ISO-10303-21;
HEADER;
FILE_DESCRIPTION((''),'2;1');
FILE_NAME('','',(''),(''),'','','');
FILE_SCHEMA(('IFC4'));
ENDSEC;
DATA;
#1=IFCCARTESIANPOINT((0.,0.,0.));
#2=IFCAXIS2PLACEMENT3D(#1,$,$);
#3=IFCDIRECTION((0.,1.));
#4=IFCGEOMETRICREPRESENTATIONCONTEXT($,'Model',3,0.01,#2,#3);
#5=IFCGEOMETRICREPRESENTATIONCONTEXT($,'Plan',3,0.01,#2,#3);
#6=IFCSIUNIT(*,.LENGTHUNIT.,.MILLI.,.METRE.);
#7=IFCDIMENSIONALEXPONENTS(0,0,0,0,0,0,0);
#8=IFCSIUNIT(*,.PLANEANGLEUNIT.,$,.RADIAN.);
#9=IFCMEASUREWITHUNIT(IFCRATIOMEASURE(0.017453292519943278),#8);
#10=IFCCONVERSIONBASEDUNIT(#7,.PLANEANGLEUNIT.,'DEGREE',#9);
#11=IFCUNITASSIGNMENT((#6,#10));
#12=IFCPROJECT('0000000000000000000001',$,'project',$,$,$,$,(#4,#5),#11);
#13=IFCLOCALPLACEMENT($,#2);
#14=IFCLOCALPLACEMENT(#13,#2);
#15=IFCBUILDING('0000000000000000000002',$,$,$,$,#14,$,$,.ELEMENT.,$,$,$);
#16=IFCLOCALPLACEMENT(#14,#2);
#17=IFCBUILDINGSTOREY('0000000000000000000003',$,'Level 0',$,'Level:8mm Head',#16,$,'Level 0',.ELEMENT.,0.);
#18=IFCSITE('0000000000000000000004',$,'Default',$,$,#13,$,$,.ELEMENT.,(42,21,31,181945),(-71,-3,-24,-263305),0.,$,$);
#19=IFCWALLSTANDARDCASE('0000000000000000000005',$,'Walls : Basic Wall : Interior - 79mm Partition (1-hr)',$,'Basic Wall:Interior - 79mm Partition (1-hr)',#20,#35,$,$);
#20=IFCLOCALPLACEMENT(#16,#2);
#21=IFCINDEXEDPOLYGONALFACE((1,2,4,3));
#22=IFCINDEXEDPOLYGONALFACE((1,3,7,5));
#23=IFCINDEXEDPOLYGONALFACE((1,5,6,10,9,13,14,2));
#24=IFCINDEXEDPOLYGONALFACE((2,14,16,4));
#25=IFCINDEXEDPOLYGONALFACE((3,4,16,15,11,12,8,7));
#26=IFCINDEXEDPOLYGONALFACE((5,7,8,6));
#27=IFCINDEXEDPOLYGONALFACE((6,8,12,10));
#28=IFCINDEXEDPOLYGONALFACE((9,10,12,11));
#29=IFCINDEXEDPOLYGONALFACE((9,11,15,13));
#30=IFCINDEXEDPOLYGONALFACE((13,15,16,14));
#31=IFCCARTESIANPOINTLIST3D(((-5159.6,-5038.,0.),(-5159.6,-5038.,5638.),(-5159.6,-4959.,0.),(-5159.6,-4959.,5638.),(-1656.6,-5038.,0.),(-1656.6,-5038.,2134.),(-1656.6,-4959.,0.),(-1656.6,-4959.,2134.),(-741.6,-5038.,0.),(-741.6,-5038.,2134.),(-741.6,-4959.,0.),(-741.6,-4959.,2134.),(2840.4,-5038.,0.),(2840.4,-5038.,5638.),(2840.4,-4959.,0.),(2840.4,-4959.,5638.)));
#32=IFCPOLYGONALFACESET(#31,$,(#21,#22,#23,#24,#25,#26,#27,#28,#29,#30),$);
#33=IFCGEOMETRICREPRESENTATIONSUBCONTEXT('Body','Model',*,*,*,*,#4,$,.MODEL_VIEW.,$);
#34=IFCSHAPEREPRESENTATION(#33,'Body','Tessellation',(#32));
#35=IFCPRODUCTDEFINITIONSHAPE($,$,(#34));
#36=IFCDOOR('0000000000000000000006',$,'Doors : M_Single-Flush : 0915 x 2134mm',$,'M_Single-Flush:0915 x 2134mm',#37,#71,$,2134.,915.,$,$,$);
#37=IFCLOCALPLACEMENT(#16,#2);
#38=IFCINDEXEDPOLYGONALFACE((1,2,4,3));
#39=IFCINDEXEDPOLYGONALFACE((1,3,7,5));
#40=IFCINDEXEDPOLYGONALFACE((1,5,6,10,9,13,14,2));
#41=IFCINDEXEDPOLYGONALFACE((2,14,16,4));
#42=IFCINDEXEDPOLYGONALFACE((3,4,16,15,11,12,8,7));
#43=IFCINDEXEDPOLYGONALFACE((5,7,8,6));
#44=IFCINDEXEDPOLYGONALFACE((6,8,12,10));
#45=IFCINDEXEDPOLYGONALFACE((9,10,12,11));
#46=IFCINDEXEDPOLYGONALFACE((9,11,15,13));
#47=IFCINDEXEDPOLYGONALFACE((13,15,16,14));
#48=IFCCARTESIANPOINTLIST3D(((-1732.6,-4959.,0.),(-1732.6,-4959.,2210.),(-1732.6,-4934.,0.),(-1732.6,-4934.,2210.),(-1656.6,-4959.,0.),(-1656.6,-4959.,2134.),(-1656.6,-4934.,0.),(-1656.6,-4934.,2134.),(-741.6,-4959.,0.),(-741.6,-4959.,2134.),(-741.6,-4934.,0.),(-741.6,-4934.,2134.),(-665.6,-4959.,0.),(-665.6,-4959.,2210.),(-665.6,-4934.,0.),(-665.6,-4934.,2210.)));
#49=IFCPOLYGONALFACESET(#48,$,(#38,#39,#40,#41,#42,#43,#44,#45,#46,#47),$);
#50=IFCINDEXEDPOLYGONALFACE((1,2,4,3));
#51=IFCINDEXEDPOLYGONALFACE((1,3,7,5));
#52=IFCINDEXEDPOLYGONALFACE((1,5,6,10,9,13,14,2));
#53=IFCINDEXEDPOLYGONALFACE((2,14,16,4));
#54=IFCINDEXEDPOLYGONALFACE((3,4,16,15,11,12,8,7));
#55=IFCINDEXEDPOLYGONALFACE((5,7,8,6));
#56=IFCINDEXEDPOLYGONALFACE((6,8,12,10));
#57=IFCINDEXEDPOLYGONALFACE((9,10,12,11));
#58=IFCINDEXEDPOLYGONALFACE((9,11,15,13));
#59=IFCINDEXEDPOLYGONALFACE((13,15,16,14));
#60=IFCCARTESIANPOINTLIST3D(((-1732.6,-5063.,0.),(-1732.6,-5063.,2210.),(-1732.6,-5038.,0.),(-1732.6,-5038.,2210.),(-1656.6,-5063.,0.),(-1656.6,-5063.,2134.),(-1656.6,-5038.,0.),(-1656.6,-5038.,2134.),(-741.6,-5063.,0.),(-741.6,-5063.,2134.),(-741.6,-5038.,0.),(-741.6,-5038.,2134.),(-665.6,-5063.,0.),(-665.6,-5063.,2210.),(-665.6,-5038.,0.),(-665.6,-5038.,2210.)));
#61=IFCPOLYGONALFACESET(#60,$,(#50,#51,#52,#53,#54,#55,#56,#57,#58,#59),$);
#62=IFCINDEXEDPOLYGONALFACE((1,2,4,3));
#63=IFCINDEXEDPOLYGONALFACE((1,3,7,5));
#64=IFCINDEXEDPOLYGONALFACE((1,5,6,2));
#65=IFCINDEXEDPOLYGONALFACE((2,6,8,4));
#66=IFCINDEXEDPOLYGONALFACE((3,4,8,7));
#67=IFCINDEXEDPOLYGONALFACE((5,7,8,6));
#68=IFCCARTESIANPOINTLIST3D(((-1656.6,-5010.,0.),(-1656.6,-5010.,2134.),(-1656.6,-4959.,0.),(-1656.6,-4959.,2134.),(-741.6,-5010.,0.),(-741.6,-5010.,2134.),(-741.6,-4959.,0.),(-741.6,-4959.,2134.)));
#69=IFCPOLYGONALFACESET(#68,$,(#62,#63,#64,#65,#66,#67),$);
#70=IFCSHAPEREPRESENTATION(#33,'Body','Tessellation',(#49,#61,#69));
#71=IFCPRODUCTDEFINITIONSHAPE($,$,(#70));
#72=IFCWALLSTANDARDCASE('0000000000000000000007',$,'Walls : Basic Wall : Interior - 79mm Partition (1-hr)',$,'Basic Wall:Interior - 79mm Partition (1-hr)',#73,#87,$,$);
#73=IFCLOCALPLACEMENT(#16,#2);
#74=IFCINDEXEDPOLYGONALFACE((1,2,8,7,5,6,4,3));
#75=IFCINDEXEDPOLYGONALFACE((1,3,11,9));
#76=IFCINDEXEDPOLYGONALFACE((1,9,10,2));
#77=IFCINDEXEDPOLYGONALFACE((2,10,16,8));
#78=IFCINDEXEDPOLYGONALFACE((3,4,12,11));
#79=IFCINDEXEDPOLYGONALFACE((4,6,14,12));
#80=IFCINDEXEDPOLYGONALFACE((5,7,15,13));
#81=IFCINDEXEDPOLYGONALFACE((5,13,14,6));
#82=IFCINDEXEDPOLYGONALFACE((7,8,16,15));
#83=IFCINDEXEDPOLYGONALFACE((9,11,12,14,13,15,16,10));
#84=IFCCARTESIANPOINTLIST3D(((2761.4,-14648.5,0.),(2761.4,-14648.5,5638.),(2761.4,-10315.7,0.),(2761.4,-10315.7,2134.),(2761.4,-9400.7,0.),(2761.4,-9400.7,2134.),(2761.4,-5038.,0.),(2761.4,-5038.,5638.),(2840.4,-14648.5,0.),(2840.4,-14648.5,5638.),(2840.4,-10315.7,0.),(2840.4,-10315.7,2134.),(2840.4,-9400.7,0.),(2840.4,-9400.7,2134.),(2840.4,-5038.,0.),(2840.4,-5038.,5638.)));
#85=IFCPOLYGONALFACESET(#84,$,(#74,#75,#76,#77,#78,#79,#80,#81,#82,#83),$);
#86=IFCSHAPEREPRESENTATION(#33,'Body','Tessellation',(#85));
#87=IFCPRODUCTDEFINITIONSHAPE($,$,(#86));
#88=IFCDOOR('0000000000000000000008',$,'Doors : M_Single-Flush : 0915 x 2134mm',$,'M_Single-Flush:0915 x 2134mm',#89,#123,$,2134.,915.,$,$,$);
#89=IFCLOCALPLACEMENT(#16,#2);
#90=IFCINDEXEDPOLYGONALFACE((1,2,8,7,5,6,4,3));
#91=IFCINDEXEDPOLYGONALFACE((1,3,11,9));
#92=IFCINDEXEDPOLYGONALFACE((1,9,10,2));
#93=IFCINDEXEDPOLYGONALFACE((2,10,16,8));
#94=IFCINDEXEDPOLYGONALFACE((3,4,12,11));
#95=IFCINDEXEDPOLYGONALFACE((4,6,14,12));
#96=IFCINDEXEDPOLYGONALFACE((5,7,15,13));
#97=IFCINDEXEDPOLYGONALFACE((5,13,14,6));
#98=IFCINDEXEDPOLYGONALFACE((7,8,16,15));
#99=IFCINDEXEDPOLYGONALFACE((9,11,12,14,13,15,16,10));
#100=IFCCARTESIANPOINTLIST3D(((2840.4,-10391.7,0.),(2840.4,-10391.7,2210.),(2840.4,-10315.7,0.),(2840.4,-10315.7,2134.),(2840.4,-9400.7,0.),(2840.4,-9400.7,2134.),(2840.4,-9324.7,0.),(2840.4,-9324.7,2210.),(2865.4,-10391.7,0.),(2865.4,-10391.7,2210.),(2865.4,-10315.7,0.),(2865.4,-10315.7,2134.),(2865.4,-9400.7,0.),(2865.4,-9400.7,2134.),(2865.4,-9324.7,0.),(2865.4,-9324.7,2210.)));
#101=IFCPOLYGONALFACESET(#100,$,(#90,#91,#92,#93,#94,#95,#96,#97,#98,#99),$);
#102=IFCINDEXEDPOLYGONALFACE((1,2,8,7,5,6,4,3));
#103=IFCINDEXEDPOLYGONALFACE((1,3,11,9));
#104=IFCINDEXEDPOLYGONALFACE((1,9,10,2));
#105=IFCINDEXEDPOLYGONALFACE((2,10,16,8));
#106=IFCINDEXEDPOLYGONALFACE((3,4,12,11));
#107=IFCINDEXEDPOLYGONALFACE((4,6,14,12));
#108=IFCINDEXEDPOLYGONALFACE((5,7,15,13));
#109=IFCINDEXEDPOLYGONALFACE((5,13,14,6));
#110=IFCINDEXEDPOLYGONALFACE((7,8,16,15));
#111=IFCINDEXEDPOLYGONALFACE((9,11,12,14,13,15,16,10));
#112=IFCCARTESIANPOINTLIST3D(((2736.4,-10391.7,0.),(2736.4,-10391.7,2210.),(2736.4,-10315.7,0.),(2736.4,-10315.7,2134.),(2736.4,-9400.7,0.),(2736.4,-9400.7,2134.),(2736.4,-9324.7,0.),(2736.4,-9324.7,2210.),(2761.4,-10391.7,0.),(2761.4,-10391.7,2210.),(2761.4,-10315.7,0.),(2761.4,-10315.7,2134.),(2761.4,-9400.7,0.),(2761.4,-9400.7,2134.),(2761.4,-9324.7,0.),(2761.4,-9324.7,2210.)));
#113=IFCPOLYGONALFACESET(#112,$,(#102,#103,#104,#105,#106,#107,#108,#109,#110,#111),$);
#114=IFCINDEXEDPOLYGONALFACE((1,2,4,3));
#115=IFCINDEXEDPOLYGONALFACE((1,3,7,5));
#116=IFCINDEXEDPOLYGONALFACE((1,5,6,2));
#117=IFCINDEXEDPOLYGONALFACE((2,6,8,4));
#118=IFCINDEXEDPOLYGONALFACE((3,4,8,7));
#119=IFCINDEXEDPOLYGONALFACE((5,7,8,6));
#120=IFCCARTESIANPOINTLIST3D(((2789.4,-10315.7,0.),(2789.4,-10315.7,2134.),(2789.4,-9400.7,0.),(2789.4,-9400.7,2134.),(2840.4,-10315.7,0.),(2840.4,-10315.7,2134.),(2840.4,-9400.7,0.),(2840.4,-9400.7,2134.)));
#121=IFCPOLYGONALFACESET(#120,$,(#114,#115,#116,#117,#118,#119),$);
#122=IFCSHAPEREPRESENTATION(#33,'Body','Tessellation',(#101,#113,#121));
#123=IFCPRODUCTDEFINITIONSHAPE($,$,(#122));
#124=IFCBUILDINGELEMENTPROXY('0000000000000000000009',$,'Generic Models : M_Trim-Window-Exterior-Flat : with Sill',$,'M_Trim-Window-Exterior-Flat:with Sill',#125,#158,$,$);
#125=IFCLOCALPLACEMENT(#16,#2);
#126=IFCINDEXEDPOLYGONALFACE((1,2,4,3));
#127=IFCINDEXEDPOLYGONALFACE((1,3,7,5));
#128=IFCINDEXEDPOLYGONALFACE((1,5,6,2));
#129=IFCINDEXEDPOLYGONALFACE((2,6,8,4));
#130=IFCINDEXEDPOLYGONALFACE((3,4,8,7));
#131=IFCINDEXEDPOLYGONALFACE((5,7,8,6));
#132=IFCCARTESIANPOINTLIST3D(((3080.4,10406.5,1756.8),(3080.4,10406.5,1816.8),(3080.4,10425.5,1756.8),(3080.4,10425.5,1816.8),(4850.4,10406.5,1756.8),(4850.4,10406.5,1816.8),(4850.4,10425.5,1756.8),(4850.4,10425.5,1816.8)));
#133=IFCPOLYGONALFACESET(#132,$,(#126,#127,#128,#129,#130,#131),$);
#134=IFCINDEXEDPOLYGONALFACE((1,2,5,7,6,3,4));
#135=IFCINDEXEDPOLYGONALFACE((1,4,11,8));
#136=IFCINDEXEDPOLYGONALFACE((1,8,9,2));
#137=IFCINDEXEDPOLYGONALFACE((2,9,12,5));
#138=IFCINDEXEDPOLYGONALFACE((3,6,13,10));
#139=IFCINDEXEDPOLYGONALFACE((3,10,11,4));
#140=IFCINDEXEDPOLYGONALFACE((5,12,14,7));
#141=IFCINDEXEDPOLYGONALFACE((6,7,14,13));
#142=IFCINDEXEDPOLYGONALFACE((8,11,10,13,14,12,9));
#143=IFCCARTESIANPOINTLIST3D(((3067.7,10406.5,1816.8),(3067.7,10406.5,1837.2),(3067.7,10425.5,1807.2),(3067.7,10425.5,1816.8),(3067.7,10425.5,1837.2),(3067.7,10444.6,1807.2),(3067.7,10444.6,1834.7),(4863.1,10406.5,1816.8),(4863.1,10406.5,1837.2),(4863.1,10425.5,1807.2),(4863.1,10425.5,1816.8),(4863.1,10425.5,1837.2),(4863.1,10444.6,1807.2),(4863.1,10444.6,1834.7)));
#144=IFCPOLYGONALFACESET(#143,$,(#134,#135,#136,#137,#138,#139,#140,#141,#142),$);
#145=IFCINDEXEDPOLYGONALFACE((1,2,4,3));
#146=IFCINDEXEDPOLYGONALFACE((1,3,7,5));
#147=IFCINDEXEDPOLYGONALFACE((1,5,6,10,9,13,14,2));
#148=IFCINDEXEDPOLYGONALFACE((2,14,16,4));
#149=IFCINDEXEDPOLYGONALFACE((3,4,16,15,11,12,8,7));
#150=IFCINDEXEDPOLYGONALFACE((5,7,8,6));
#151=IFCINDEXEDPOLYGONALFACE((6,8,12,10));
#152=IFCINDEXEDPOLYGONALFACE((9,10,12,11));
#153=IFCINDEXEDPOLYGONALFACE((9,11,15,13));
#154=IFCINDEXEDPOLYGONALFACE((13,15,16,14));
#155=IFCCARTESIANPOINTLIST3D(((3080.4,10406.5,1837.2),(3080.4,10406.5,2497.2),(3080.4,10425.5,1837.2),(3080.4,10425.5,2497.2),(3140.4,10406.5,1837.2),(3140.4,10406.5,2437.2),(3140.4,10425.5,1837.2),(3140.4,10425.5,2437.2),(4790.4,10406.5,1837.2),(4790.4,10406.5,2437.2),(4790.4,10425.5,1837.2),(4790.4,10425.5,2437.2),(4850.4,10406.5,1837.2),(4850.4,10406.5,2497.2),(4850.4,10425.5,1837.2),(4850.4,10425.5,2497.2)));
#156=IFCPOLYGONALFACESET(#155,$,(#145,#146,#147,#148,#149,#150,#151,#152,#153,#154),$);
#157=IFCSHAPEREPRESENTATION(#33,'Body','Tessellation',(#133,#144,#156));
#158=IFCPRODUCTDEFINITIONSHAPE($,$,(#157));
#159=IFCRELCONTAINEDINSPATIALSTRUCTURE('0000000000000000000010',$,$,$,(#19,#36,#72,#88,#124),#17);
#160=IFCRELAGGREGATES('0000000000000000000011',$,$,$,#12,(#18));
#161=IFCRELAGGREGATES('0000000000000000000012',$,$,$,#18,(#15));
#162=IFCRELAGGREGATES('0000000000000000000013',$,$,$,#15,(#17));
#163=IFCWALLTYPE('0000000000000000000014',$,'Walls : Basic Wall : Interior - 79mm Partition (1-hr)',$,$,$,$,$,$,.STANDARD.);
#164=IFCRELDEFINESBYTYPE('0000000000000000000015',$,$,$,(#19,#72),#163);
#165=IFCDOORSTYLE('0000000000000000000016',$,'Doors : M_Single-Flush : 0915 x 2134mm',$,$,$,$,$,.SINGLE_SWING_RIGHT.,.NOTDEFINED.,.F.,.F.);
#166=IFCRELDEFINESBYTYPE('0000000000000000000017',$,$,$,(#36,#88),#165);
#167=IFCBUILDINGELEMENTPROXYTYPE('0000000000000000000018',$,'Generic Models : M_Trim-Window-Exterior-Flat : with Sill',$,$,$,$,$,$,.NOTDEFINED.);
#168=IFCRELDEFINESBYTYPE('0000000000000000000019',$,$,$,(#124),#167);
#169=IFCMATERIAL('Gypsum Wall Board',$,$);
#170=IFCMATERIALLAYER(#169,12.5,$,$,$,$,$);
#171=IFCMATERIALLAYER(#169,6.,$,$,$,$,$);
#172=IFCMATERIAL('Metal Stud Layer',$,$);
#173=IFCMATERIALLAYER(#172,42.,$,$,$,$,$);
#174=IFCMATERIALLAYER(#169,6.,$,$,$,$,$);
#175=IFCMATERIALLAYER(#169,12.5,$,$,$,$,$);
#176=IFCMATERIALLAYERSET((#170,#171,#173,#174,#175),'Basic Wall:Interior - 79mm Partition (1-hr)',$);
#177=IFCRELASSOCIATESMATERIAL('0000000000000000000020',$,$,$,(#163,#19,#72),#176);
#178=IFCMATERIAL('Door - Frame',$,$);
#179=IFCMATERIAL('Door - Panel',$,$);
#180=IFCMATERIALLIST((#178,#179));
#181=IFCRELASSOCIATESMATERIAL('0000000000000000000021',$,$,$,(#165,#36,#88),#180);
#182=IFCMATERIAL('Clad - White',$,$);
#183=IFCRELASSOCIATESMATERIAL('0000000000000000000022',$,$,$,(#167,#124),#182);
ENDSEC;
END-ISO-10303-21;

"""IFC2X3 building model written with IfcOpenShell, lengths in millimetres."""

from ifc_helpers import new_model, entity, si_unit, converted_unit, direction, frame, frame_2d, origin, origin_2d_with_axis, place, context, subcontext, project, spatial, polyline, rectangle, outline, extrude, clip, bounded_halfspace, source, transform, mapped, material, material_list, layer, layer_set, layer_usage, type_object, type_shapes, element, fill, save


model = new_model("IFC2X3")

# Units and contexts
model_context = context("Model", 3, precision=0.01, world=origin(), true_north=direction((0.0, 1.0)))
plan_context = context("Plan", 3, precision=0.01, world=origin(), true_north=direction((0.0, 1.0)))
body_context = subcontext(model_context, "Body", "Model", "MODEL_VIEW")
ifc_project = project(units=[si_unit("LENGTHUNIT", "METRE", prefix="MILLI"), converted_unit("PLANEANGLEUNIT", "DEGREE", entity("IfcRatioMeasure", 0.017453292519943278), si_unit("PLANEANGLEUNIT", "RADIAN"), dimensions=[0, 0, 0, 0, 0, 0, 0])], contexts=[model_context, plan_context])

# Site, building, storey
site_placement = place(None, origin())
site = spatial("IfcSite", under=ifc_project, at=site_placement, Name="Default", CompositionType="ELEMENT", RefLatitude=(42, 21, 31, 181945), RefLongitude=(-71, -3, -24, -263305), RefElevation=0.0)
building_placement = place(site_placement, origin())
building = spatial("IfcBuilding", under=site, at=building_placement, CompositionType="ELEMENT")
storey_placement = place(building_placement, origin())
storey = spatial("IfcBuildingStorey", under=building, at=storey_placement, Name="Level 0", ObjectType="Level:8mm Head", LongName="Level 0", CompositionType="ELEMENT", Elevation=0.0)

# Shared definitions
ifc_material_1 = material(Name="Metal Stud Layer")
ifc_material_2 = material(Name="Gypsum Wall Board")

# Shared definitions
ifc_material_3 = material(Name="Door - Frame")
ifc_material_4 = material(Name="Door - Panel")
ifc_material_list = material_list([ifc_material_3, ifc_material_4])

# Walls, openings, doors
ifc_layer_1 = layer(ifc_material_2, 12.5)
ifc_layer_2 = layer(ifc_material_2, 6.0)
ifc_layer_3 = layer(ifc_material_1, 42.0)
ifc_layer_4 = layer(ifc_material_2, 6.0)
ifc_layer_5 = layer(ifc_material_2, 12.5)
ifc_layer_set_1 = layer_set([ifc_layer_1, ifc_layer_2, ifc_layer_3, ifc_layer_4, ifc_layer_5], Name="Basic Wall:Interior - 79mm Partition (1-hr)")
ifc_layer_usage_1 = layer_usage(ifc_layer_set_1, "AXIS2", "NEGATIVE", 39.5)
wall_type_1 = type_object("IfcWallType", Name="Walls : Basic Wall : Interior - 79mm Partition (1-hr)", PredefinedType="STANDARD", material=ifc_layer_set_1)
wall_1_placement = place(storey_placement, frame((-5159.6, -4998.5, 0.0)))
wall_1 = element("IfcWallStandardCase", 1, at=wall_1_placement, inside=storey, type_object=wall_type_1, material=ifc_layer_usage_1, Name="Walls : Basic Wall : Interior - 79mm Partition (1-hr)", ObjectType="Basic Wall:Interior - 79mm Partition (1-hr)", context=body_context, shape_type="Clipping", body=[
    clip(extrude(rectangle(XDim=8000.0, YDim=79.0, at=frame_2d((4000.0, 0.0), x_axis=(1.0, 0.0))), origin(), (0.0, 0.0, 1.0), 5638.0), bounded_halfspace(frame((0.0, -39.5, 5638.0), z_axis=(0.0, 0.0, -1.0), x_axis=(0.0, -1.0, 0.0)), True, frame((0.0, -39.5, 5638.0)), polyline([(0.0, 0.0), (2414320.8, 0.0), (2438400.0, 0.0), (2438400.0, 24079.2), (0.0, 24079.2), (0.0, 0.0)]))),
])
opening_1_placement = place(wall_1_placement, frame((3503.0, -39.5, 0.0)))
opening_1 = element("IfcOpeningElement", 2, at=opening_1_placement, cuts=wall_1, ObjectType="Opening", context=body_context, shape_type="SweptSolid", body=[
    extrude(rectangle(XDim=915.0, YDim=2134.0, at=frame_2d((1067.0, 457.5), x_axis=(0.0, 1.0))), frame((0.0, 0.0, 0.0), z_axis=(0.0, 1.0, 0.0), x_axis=(0.0, 0.0, 1.0)), (0.0, 0.0, 1.0), 79.0),
])
door_style_1 = type_object("IfcDoorStyle", Name="Doors : M_Single-Flush : 0915 x 2134mm", ConstructionType="NOTDEFINED", OperationType="SINGLE_SWING_RIGHT", ParameterTakesPrecedence=False, Sizeable=False, material=ifc_material_list)
shared_shape_1 = source(origin(), body_context, "Body", "SweptSolid", [
    extrude(outline(polyline([(-533.5, -1124.0), (533.5, -1124.0), (533.5, 1086.0), (457.5, 1086.0), (457.5, -1048.0), (-457.5, -1048.0), (-457.5, 1086.0), (-533.5, 1086.0), (-533.5, -1124.0)])), frame((457.5, 79.0, 1086.0), z_axis=(0.0, 1.0, 0.0), x_axis=(1.0, 0.0, 0.0)), (0.0, 0.0, 1.0), 25.0),
    extrude(outline(polyline([(-1124.0, -533.5), (1086.0, -533.5), (1086.0, -457.5), (-1048.0, -457.5), (-1048.0, 457.5), (1086.0, 457.5), (1086.0, 533.5), (-1124.0, 533.5), (-1124.0, -533.5)])), frame((457.5, -25.0, 1086.0), z_axis=(0.0, 1.0, 0.0), x_axis=(0.0, 0.0, -1.0)), (0.0, 0.0, 1.0), 25.0),
    extrude(rectangle(XDim=51.0, YDim=915.0, at=origin_2d_with_axis()), frame((457.5, 53.5, 0.0), z_axis=(0.0, 0.0, 1.0), x_axis=(0.0, 1.0, 0.0)), (0.0, 0.0, 1.0), 2134.0),
])
type_shapes(door_style_1, [shared_shape_1])
door_1_placement = place(opening_1_placement, origin())
door_1 = element("IfcDoor", 3, at=door_1_placement, inside=storey, type_object=door_style_1, material=ifc_material_list, Name="Doors : M_Single-Flush : 0915 x 2134mm", ObjectType="M_Single-Flush:0915 x 2134mm", OverallHeight=2134.0, OverallWidth=915.0, context=body_context, shape_type="MappedRepresentation", body=[
    mapped(shared_shape_1, transform((0.0, 0.0, 0.0), scale=1.0)),
])
fill(opening_1, door_1)
wall_2_placement = place(storey_placement, frame((2800.9, -5038.0, 0.0), z_axis=(0.0, 0.0, 1.0), x_axis=(0.0, -1.0, 0.0)))
wall_2 = element("IfcWallStandardCase", 4, at=wall_2_placement, inside=storey, type_object=wall_type_1, material=ifc_layer_usage_1, Name="Walls : Basic Wall : Interior - 79mm Partition (1-hr)", ObjectType="Basic Wall:Interior - 79mm Partition (1-hr)", context=body_context, shape_type="Clipping", body=[
    clip(extrude(rectangle(XDim=9610.5, YDim=79.0, at=frame_2d((4805.3, 0.0), x_axis=(-1.0, 0.0))), origin(), (0.0, 0.0, 1.0), 5638.0), bounded_halfspace(frame((0.0, -39.5, 5638.0), z_axis=(0.0, 0.0, -1.0), x_axis=(1.0, 0.0, 0.0)), True, frame((0.0, -39.5, 5638.0)), polyline([(0.0, 0.0), (2929280.4, 0.0), (2929280.4, 24079.2), (0.0, 24079.2), (0.0, 0.0)]))),
])
opening_2_placement = place(wall_2_placement, frame((4362.6, -39.5, 0.0)))
opening_2 = element("IfcOpeningElement", 5, at=opening_2_placement, cuts=wall_2, ObjectType="Opening", context=body_context, shape_type="SweptSolid", body=[
    extrude(rectangle(XDim=915.0, YDim=2134.0, at=frame_2d((1067.0, 457.5), x_axis=(0.0, 1.0))), frame((0.0, 0.0, 0.0), z_axis=(0.0, 1.0, 0.0), x_axis=(0.0, 0.0, 1.0)), (0.0, 0.0, 1.0), 79.0),
])
door_2_placement = place(opening_2_placement, origin())
door_2 = element("IfcDoor", 6, at=door_2_placement, inside=storey, type_object=door_style_1, material=ifc_material_list, Name="Doors : M_Single-Flush : 0915 x 2134mm", ObjectType="M_Single-Flush:0915 x 2134mm", OverallHeight=2134.0, OverallWidth=915.0, context=body_context, shape_type="MappedRepresentation", body=[
    mapped(shared_shape_1, transform((0.0, 0.0, 0.0), scale=1.0)),
])
fill(opening_2, door_2)

# Building element proxy
ifc_material_5 = material(Name="Clad - White")
building_element_proxy_type_1 = type_object("IfcBuildingElementProxyType", Name="Generic Models : M_Trim-Window-Exterior-Flat : with Sill", PredefinedType="NOTDEFINED", material=ifc_material_5)
shared_shape_2 = source(origin(), body_context, "Body", "SweptSolid", [
    extrude(rectangle(XDim=1770.0, YDim=60.0, at=frame_2d((0.0, 0.0), x_axis=(1.0, 0.0))), frame((0.0, -650.4, 0.0), z_axis=(0.0, 0.0, 1.0), x_axis=(-1.0, 0.0, 0.0)), (0.0, 0.0, 1.0), 19.0),
    extrude(outline(polyline([(-19.0, -15.2), (0.0, -15.2), (0.0, -5.7), (19.0, -5.7), (19.0, 14.8), (0.0, 14.8), (-19.0, 12.3), (-19.0, -15.2)])), frame((-897.7, -614.8, 19.0), z_axis=(1.0, 0.0, 0.0), x_axis=(0.0, 0.0, -1.0)), (0.0, 0.0, 1.0), 1795.4),
    extrude(outline(polyline([(-345.0, -885.0), (315.0, -885.0), (315.0, -825.0), (-285.0, -825.0), (-285.0, 825.0), (315.0, 825.0), (315.0, 885.0), (-345.0, 885.0), (-345.0, -885.0)])), frame((0.0, -285.0, 0.0), z_axis=(0.0, 0.0, 1.0), x_axis=(0.0, -1.0, 0.0)), (0.0, 0.0, 1.0), 19.0),
])
type_shapes(building_element_proxy_type_1, [shared_shape_2])
for number, where, z_axis, x_axis, name in (
    (7, (3965.4, 10406.5, 2437.2), (0.0, 1.0, 0.0), (-1.0, 0.0, 0.0), "Generic Models : M_Trim-Window-Exterior-Flat : with Sill"),
):
    element("IfcBuildingElementProxy", number, at=place(storey_placement, frame(where, z_axis=z_axis, x_axis=x_axis)), inside=storey, type_object=building_element_proxy_type_1, material=ifc_material_5, Name=name, ObjectType="M_Trim-Window-Exterior-Flat:with Sill", context=body_context, shape_type="MappedRepresentation", body=[
        mapped(shared_shape_2, transform((0.0, 0.0, 0.0), scale=1.0)),
    ])

save(model, "model.ifc")
